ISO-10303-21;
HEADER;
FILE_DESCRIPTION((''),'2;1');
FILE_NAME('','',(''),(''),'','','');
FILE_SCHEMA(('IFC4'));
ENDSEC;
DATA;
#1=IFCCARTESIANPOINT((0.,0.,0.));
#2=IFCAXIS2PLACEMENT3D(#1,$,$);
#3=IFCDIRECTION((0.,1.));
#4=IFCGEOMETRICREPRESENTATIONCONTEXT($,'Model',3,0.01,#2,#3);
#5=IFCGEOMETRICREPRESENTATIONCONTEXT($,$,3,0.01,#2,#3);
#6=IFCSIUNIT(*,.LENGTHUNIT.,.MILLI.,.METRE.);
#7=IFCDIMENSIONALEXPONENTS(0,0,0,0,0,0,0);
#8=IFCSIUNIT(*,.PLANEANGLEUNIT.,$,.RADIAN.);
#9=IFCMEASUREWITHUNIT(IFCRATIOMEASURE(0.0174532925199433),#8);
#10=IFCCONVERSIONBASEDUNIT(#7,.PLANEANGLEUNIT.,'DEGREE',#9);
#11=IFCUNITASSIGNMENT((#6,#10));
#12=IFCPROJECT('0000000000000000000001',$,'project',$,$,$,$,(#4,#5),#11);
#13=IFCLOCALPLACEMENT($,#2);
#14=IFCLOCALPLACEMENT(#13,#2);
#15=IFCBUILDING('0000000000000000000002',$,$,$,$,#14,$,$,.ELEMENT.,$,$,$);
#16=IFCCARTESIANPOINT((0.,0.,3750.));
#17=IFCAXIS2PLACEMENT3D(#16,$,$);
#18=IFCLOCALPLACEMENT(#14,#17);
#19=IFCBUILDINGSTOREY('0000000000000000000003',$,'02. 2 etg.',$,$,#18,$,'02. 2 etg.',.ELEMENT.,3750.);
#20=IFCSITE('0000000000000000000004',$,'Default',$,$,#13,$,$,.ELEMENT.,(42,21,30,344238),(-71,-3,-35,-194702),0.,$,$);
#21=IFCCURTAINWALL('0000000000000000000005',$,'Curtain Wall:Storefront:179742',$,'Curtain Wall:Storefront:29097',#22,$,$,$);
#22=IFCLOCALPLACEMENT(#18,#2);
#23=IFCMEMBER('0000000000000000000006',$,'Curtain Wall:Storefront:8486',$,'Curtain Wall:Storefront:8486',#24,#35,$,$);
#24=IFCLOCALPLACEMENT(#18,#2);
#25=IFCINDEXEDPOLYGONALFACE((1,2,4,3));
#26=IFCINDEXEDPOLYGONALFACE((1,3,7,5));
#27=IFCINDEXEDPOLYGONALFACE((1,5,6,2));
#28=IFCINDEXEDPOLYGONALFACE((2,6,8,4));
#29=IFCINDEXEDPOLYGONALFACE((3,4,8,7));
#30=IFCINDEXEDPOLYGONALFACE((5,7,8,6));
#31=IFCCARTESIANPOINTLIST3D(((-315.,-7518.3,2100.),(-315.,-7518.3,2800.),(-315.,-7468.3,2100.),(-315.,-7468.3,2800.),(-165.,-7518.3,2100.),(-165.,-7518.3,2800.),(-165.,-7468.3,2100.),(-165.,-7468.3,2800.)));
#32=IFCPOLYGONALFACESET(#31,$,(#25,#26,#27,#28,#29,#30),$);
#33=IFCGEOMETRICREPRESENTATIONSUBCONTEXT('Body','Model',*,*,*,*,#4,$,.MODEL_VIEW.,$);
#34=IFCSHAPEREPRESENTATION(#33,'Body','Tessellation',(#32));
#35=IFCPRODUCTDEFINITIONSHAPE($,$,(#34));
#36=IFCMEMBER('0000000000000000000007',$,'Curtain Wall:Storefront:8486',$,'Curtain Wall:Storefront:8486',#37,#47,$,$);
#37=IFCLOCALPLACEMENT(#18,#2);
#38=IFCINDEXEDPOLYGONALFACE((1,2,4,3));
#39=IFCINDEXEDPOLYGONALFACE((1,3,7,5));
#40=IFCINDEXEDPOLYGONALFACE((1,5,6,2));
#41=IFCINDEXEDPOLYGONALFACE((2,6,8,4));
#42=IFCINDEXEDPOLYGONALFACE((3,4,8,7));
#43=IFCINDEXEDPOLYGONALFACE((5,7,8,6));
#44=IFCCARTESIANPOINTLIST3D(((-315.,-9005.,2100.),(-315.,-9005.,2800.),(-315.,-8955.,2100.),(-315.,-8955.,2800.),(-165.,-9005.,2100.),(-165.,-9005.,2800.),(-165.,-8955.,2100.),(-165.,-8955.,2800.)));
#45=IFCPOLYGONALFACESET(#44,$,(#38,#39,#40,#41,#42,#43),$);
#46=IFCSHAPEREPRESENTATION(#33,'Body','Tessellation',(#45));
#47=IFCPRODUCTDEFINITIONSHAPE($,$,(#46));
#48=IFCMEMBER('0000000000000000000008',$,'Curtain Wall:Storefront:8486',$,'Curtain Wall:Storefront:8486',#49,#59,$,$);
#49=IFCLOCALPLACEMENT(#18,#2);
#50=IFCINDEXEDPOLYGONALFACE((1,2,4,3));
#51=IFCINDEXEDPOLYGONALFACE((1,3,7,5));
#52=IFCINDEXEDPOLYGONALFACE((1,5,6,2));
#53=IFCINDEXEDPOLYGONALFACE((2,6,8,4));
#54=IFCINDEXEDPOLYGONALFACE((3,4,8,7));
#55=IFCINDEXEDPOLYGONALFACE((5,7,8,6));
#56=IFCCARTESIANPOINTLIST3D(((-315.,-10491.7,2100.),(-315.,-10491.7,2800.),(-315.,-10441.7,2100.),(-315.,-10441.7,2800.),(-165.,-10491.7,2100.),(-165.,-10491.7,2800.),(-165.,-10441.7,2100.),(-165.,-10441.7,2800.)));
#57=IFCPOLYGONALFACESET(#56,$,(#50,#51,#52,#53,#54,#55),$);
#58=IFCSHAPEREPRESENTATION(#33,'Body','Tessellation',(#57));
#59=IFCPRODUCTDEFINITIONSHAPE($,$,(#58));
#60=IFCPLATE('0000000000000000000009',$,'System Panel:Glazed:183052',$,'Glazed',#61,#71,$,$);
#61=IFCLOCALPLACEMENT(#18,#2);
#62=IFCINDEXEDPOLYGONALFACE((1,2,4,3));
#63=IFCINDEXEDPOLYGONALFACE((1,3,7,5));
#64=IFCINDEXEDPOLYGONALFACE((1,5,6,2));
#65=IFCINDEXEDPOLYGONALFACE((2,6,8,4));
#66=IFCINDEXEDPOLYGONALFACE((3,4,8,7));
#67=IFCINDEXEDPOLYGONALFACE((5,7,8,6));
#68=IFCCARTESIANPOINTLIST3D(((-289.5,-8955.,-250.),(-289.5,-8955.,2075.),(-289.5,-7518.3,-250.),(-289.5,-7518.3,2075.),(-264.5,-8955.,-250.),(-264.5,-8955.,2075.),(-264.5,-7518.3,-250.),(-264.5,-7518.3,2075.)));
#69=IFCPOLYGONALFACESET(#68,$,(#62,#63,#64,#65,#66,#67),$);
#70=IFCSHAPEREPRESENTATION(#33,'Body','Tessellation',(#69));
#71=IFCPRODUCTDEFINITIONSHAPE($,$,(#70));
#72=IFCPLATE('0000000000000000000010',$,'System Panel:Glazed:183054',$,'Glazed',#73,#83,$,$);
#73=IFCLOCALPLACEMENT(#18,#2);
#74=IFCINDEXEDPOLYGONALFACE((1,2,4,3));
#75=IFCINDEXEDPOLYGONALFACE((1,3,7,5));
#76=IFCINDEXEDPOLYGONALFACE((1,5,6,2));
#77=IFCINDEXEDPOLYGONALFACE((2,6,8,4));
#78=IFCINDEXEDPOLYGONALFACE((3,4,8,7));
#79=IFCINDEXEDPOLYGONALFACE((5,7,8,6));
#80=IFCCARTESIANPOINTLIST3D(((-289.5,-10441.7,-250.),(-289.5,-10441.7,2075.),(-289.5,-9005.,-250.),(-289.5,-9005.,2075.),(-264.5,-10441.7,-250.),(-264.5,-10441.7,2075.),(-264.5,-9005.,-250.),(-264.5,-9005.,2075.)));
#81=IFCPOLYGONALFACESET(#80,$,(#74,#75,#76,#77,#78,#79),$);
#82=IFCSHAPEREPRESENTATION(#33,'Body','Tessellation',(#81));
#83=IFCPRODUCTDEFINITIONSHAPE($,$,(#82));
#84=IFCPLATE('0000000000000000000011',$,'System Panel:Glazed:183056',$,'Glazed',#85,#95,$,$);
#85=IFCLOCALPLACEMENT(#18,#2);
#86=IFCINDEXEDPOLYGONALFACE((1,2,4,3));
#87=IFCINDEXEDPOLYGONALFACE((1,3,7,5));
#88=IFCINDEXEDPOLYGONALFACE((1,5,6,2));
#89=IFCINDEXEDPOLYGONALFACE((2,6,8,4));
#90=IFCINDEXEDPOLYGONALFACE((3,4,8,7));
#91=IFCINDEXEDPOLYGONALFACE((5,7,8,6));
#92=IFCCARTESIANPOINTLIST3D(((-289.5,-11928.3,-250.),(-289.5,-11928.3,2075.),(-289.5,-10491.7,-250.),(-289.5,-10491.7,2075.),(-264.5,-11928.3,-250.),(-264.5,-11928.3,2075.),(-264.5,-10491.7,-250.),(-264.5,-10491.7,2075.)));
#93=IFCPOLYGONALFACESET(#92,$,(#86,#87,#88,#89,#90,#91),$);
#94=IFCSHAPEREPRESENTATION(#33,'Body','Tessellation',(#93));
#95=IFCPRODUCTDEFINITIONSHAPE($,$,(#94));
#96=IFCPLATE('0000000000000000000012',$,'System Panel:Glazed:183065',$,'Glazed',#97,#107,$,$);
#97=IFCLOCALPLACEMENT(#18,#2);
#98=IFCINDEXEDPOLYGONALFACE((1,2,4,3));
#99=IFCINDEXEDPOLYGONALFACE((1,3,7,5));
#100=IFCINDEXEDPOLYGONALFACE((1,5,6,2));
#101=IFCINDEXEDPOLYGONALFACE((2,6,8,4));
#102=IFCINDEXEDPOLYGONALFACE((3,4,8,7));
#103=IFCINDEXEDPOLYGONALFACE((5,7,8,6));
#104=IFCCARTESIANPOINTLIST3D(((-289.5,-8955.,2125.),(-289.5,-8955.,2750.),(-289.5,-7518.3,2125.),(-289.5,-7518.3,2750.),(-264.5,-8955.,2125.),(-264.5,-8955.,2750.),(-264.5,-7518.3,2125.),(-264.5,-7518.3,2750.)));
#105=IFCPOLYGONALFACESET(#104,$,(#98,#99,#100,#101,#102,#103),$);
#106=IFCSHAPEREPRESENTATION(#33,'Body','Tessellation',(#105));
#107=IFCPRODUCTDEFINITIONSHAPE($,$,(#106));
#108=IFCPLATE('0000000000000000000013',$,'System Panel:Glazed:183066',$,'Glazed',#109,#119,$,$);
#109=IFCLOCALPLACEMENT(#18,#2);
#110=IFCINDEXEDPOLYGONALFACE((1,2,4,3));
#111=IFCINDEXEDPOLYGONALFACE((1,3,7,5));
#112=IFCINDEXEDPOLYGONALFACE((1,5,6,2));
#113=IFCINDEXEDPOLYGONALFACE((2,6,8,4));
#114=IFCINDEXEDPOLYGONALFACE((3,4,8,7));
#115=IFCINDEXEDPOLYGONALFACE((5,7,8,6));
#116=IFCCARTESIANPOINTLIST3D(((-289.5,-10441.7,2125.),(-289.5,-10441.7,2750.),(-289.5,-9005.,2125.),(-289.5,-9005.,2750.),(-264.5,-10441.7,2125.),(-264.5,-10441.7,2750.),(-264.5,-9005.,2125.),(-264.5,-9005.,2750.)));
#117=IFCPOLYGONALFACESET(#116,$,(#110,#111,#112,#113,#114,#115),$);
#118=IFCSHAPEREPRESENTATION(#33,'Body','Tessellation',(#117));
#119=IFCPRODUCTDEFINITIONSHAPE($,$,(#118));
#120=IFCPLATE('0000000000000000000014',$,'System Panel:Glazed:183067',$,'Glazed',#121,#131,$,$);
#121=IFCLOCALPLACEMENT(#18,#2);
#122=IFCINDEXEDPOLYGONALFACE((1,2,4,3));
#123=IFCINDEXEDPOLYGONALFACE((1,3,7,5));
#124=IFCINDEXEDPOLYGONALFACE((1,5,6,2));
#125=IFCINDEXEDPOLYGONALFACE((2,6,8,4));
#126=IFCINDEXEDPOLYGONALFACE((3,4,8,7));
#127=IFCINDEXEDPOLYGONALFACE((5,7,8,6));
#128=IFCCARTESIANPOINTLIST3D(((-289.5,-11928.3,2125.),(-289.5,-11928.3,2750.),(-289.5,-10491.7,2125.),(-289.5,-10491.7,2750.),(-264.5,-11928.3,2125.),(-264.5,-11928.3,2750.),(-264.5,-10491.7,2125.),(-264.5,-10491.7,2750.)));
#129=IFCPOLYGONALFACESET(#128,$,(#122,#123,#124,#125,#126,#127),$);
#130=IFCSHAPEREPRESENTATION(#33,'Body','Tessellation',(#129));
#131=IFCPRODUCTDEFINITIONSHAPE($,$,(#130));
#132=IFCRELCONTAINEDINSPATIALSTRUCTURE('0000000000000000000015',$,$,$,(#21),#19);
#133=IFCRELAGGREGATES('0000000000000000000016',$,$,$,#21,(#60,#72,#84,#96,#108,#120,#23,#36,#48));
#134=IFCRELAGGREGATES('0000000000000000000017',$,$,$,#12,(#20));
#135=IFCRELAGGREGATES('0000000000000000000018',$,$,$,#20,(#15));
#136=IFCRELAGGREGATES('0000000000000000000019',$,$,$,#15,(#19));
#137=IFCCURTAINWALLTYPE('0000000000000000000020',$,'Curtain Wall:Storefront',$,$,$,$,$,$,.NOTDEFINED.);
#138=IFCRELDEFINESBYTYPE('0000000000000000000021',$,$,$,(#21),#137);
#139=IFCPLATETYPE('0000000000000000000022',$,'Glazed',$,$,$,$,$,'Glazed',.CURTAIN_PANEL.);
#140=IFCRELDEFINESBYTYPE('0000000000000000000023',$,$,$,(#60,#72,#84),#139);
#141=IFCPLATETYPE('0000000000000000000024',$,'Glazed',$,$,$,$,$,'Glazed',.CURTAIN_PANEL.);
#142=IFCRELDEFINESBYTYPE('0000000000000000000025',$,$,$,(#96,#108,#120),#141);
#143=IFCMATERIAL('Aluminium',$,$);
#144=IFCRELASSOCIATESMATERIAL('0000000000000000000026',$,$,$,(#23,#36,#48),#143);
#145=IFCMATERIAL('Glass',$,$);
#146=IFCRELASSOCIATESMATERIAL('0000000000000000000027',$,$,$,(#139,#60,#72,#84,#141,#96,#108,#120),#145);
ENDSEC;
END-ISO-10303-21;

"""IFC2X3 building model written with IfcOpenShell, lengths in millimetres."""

from ifc_helpers import new_model, entity, si_unit, converted_unit, direction, frame, frame_2d, origin, origin_2d_with_axis, place, context, subcontext, project, spatial, rectangle, extrude, source, transform, mapped, material, type_object, type_shapes, element, aggregate, save


model = new_model("IFC2X3")

# Units and contexts
model_context = context("Model", 3, precision=0.01, world=origin(), true_north=direction((0.0, 1.0)))
context_of_model = context(None, 3, precision=0.01, world=origin(), true_north=direction((0.0, 1.0)))
body_context = subcontext(model_context, "Body", "Model", "MODEL_VIEW")
ifc_project = project(units=[si_unit("LENGTHUNIT", "METRE", prefix="MILLI"), converted_unit("PLANEANGLEUNIT", "DEGREE", entity("IfcRatioMeasure", 0.0174532925199433), si_unit("PLANEANGLEUNIT", "RADIAN"), dimensions=[0, 0, 0, 0, 0, 0, 0])], contexts=[model_context, context_of_model])

# Site, building, storey
site_placement = place(None, origin())
site = spatial("IfcSite", under=ifc_project, at=site_placement, Name="Default", CompositionType="ELEMENT", RefLatitude=(42, 21, 30, 344238), RefLongitude=(-71, -3, -35, -194702), RefElevation=0.0)
building_placement = place(site_placement, origin())
building = spatial("IfcBuilding", under=site, at=building_placement, CompositionType="ELEMENT")
storey_placement = place(building_placement, frame((0.0, 0.0, 3750.0)))
storey = spatial("IfcBuildingStorey", under=building, at=storey_placement, Name="02. 2 etg.", LongName="02. 2 etg.", CompositionType="ELEMENT", Elevation=3750.0)

# Curtain wall, members, plates
curtain_wall_type = type_object("IfcCurtainWallType", Name="Curtain Wall:Storefront", PredefinedType="NOTDEFINED")
curtain_wall_placement = place(storey_placement, frame((0.0, 0.0, -3750.0)))
curtain_wall = element("IfcCurtainWall", 1, at=curtain_wall_placement, inside=storey, type_object=curtain_wall_type, Name="Curtain Wall:Storefront:179742", ObjectType="Curtain Wall:Storefront:29097")
ifc_material_1 = material(Name="Aluminium")
member_1_placement = place(curtain_wall_placement, frame((-315.0, -7518.3, 5850.0)))
member_1 = element("IfcMember", 2, at=member_1_placement, material=ifc_material_1, Name="Curtain Wall:Storefront:8486", ObjectType="Curtain Wall:Storefront:8486", context=body_context, shape_type="SweptSolid", body=[
    extrude(rectangle(XDim=150.0, YDim=50.0, at=frame_2d((0.0, 0.0), x_axis=(1.0, 0.0))), frame((75.0, 25.0, 0.0)), (0.0, 0.0, 1.0), 700.0),
])
member_2_placement = place(curtain_wall_placement, frame((-315.0, -9005.0, 5850.0)))
member_2 = element("IfcMember", 3, at=member_2_placement, material=ifc_material_1, Name="Curtain Wall:Storefront:8486", ObjectType="Curtain Wall:Storefront:8486", context=body_context, shape_type="SweptSolid", body=[
    extrude(rectangle(XDim=150.0, YDim=50.0, at=frame_2d((0.0, 0.0), x_axis=(1.0, 0.0))), frame((75.0, 25.0, 0.0)), (0.0, 0.0, 1.0), 700.0),
])
member_3_placement = place(curtain_wall_placement, frame((-315.0, -10491.7, 5850.0)))
member_3 = element("IfcMember", 4, at=member_3_placement, material=ifc_material_1, Name="Curtain Wall:Storefront:8486", ObjectType="Curtain Wall:Storefront:8486", context=body_context, shape_type="SweptSolid", body=[
    extrude(rectangle(XDim=150.0, YDim=50.0, at=frame_2d((0.0, 0.0), x_axis=(1.0, 0.0))), frame((75.0, 25.0, 0.0)), (0.0, 0.0, 1.0), 700.0),
])
ifc_material_2 = material(Name="Glass")
plate_type_1 = type_object("IfcPlateType", Name="Glazed", ElementType="Glazed", PredefinedType="CURTAIN_PANEL", material=ifc_material_2)
shared_shape_1 = source(origin(), body_context, "Body", "SweptSolid", [
    extrude(rectangle(XDim=25.0, YDim=1436.7, at=origin_2d_with_axis()), frame((718.3, 12.5, 0.0), z_axis=(0.0, 0.0, 1.0), x_axis=(0.0, 1.0, 0.0)), (0.0, 0.0, 1.0), 2325.0),
])
type_shapes(plate_type_1, [shared_shape_1])
plate_1_placement = place(curtain_wall_placement, frame((-289.5, -7518.3, 3500.0), z_axis=(0.0, 0.0, 1.0), x_axis=(0.0, -1.0, 0.0)))
plate_1 = element("IfcPlate", 5, at=plate_1_placement, type_object=plate_type_1, material=ifc_material_2, Name="System Panel:Glazed:183052", ObjectType="Glazed", context=body_context, shape_type="MappedRepresentation", body=[
    mapped(shared_shape_1, transform((0.0, 0.0, 0.0), scale=1.0)),
])
plate_2_placement = place(curtain_wall_placement, frame((-289.5, -9005.0, 3500.0), z_axis=(0.0, 0.0, 1.0), x_axis=(0.0, -1.0, 0.0)))
plate_2 = element("IfcPlate", 6, at=plate_2_placement, type_object=plate_type_1, material=ifc_material_2, Name="System Panel:Glazed:183054", ObjectType="Glazed", context=body_context, shape_type="MappedRepresentation", body=[
    mapped(shared_shape_1, transform((0.0, 0.0, 0.0), scale=1.0)),
])
plate_3_placement = place(curtain_wall_placement, frame((-289.5, -10491.7, 3500.0), z_axis=(0.0, 0.0, 1.0), x_axis=(0.0, -1.0, 0.0)))
plate_3 = element("IfcPlate", 7, at=plate_3_placement, type_object=plate_type_1, material=ifc_material_2, Name="System Panel:Glazed:183056", ObjectType="Glazed", context=body_context, shape_type="MappedRepresentation", body=[
    mapped(shared_shape_1, transform((0.0, 0.0, 0.0), scale=1.0)),
])
plate_type_2 = type_object("IfcPlateType", Name="Glazed", ElementType="Glazed", PredefinedType="CURTAIN_PANEL", material=ifc_material_2)
shared_shape_2 = source(origin(), body_context, "Body", "SweptSolid", [
    extrude(rectangle(XDim=25.0, YDim=1436.7, at=origin_2d_with_axis()), frame((718.3, 12.5, 0.0), z_axis=(0.0, 0.0, 1.0), x_axis=(0.0, 1.0, 0.0)), (0.0, 0.0, 1.0), 625.0),
])
type_shapes(plate_type_2, [shared_shape_2])
plate_4_placement = place(curtain_wall_placement, frame((-289.5, -7518.3, 5875.0), z_axis=(0.0, 0.0, 1.0), x_axis=(0.0, -1.0, 0.0)))
plate_4 = element("IfcPlate", 8, at=plate_4_placement, type_object=plate_type_2, material=ifc_material_2, Name="System Panel:Glazed:183065", ObjectType="Glazed", context=body_context, shape_type="MappedRepresentation", body=[
    mapped(shared_shape_2, transform((0.0, 0.0, 0.0), scale=1.0)),
])
plate_5_placement = place(curtain_wall_placement, frame((-289.5, -9005.0, 5875.0), z_axis=(0.0, 0.0, 1.0), x_axis=(0.0, -1.0, 0.0)))
plate_5 = element("IfcPlate", 9, at=plate_5_placement, type_object=plate_type_2, material=ifc_material_2, Name="System Panel:Glazed:183066", ObjectType="Glazed", context=body_context, shape_type="MappedRepresentation", body=[
    mapped(shared_shape_2, transform((0.0, 0.0, 0.0), scale=1.0)),
])
plate_6_placement = place(curtain_wall_placement, frame((-289.5, -10491.7, 5875.0), z_axis=(0.0, 0.0, 1.0), x_axis=(0.0, -1.0, 0.0)))
plate_6 = element("IfcPlate", 10, at=plate_6_placement, type_object=plate_type_2, material=ifc_material_2, Name="System Panel:Glazed:183067", ObjectType="Glazed", context=body_context, shape_type="MappedRepresentation", body=[
    mapped(shared_shape_2, transform((0.0, 0.0, 0.0), scale=1.0)),
])
aggregate(curtain_wall, [plate_1, plate_2, plate_3, plate_4, plate_5, plate_6, member_1, member_2, member_3])

save(model, "model.ifc")
